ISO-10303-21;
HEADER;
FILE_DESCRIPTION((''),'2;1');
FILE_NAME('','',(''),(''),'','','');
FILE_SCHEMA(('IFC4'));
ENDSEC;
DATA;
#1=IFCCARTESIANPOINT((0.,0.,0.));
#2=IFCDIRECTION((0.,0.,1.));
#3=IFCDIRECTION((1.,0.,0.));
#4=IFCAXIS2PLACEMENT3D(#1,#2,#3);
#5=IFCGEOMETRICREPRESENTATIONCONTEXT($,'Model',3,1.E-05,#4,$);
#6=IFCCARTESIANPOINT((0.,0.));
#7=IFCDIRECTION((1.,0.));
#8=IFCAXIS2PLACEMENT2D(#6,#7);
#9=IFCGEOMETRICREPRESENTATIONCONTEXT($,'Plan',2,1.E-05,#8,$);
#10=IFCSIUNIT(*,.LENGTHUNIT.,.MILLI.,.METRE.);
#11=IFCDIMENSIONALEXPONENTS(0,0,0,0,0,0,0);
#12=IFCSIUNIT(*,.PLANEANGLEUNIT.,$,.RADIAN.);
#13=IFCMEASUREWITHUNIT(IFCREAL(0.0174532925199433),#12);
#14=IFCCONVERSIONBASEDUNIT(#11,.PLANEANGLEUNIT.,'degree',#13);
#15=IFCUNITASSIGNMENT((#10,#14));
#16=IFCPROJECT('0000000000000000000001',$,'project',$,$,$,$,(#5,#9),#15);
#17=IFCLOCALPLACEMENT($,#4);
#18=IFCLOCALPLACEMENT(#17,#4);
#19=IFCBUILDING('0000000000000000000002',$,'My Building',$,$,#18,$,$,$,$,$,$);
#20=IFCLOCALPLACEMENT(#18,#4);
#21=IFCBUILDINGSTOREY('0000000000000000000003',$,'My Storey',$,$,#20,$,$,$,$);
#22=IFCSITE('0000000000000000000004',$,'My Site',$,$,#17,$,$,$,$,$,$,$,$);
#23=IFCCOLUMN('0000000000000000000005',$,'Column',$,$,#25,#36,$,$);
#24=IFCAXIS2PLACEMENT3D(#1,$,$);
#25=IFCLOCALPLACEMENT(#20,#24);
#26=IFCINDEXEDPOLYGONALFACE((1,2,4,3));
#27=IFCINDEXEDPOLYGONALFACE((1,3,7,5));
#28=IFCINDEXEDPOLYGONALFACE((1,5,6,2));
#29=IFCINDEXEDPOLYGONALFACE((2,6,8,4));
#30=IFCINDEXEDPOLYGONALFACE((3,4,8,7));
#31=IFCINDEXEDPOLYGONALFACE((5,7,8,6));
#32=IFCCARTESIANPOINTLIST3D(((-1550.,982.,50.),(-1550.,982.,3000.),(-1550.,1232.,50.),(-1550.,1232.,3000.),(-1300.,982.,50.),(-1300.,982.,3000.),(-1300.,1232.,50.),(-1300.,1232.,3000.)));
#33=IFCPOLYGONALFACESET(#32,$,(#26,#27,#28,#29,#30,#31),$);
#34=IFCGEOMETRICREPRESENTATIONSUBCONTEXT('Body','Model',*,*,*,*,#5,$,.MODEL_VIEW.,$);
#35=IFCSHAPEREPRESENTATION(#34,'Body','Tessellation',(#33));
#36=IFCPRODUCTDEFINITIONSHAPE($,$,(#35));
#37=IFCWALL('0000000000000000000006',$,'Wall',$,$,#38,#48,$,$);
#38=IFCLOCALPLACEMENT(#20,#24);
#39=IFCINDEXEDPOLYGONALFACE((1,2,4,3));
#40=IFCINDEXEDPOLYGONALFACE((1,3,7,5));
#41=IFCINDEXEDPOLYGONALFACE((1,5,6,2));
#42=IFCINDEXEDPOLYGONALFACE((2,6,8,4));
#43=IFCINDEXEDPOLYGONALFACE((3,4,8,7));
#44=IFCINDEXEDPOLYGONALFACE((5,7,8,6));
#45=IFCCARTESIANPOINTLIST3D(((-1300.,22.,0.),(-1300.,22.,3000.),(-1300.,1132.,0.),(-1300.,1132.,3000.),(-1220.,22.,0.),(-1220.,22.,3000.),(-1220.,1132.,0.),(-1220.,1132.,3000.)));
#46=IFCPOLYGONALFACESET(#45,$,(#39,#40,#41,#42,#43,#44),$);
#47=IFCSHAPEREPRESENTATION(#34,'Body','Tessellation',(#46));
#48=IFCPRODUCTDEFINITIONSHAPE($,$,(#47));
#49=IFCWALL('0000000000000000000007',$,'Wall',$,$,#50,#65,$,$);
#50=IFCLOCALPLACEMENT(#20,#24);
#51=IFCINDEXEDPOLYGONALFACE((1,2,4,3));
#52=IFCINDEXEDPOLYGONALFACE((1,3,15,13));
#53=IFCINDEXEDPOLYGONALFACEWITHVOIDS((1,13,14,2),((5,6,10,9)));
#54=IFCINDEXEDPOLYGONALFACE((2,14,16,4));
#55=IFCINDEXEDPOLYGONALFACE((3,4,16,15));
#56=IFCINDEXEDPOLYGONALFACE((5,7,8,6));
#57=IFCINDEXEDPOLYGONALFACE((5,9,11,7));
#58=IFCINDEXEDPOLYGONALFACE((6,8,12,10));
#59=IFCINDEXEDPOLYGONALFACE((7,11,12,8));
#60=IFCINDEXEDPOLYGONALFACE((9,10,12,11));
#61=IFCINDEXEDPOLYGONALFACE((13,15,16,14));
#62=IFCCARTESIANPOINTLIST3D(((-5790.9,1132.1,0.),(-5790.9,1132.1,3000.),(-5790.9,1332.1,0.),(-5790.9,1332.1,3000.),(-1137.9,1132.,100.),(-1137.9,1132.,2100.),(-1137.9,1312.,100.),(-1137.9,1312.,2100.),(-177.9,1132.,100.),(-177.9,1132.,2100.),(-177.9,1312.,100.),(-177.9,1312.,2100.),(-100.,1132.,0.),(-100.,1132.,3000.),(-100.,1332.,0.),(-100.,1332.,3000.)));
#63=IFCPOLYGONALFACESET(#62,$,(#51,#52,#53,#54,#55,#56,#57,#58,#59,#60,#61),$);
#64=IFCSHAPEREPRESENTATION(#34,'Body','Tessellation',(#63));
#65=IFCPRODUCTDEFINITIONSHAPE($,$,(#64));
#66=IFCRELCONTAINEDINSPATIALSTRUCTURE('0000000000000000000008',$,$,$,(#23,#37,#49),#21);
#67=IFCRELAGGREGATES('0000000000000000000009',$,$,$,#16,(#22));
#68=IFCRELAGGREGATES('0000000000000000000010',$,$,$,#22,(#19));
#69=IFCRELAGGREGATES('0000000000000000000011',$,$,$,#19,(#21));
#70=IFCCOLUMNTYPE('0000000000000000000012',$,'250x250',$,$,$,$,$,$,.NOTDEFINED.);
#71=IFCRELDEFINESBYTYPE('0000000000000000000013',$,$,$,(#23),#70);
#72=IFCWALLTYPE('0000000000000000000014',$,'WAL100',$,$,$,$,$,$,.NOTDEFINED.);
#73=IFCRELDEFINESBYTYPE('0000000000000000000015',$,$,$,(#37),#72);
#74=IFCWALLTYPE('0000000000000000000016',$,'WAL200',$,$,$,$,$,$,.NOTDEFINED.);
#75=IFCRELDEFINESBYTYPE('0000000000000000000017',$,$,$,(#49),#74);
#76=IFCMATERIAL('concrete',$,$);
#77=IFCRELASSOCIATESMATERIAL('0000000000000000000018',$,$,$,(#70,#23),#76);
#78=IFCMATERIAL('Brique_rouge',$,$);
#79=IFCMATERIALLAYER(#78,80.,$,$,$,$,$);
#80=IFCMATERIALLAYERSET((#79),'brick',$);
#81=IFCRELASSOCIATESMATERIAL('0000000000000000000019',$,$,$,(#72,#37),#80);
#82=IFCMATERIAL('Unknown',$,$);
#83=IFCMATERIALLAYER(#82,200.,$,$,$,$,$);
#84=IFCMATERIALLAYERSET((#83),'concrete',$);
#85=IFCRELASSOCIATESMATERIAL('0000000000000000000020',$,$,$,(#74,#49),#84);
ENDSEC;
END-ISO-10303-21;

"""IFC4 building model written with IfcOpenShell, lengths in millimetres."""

from ifc_helpers import new_model, entity, si_unit, converted_unit, frame, origin_with_axes, origin_2d_with_axis, place, context, subcontext, project, spatial, line, indexed_curve, rectangle, outline, extrude, source, transform, mapped, material, layer, layer_set, layer_usage, material_profile, profile_set, profile_usage, type_object, element, save


model = new_model("IFC4")

# Units and contexts
model_context = context("Model", 3, precision=1e-05, world=origin_with_axes())
plan_context = context("Plan", 2, precision=1e-05, world=origin_2d_with_axis())
body_context_1 = subcontext(model_context, "Body", "Model", "MODEL_VIEW")
ifc_project = project(units=[si_unit("LENGTHUNIT", "METRE", prefix="MILLI"), converted_unit("PLANEANGLEUNIT", "degree", entity("IfcReal", 0.0174532925199433), si_unit("PLANEANGLEUNIT", "RADIAN"), dimensions=[0, 0, 0, 0, 0, 0, 0])], contexts=[model_context, plan_context])

# Site, building, storey
site_placement = place(None, origin_with_axes())
site = spatial("IfcSite", under=ifc_project, at=site_placement, Name="My Site")
building_placement = place(site_placement, origin_with_axes())
building = spatial("IfcBuilding", under=site, at=building_placement, Name="My Building")
storey_placement = place(building_placement, origin_with_axes())
storey = spatial("IfcBuildingStorey", under=building, at=storey_placement, Name="My Storey")

# Column
ifc_material_1 = material(Name="concrete")
ifc_material_profile = material_profile(ifc_material_1, rectangle(XDim=250.0, YDim=250.0))
ifc_profile_set = profile_set([ifc_material_profile], Name="concrete")
ifc_profile_usage = profile_usage(ifc_profile_set)
column_type = type_object("IfcColumnType", Name="250x250", PredefinedType="NOTDEFINED", material=ifc_profile_set)
column_placement = place(storey_placement, frame((-1425.0, 1107.0, 50.0), z_axis=(0.0, 0.0, 1.0), x_axis=(1.0, 0.0, 0.0)))
element("IfcColumn", 1, at=column_placement, inside=storey, type_object=column_type, material=ifc_profile_usage, Name="Column", context=body_context_1, shape_type="SweptSolid", body=[
    extrude(rectangle(XDim=250.0, YDim=250.0), origin_with_axes(), (0.0, 0.0, 1.0), 2950.0),
])

# Wall
ifc_material_2 = material(Name="Brique_rouge")
ifc_layer_1 = layer(ifc_material_2, 80.0)
ifc_layer_set_1 = layer_set([ifc_layer_1], Name="brick")
ifc_layer_usage_1 = layer_usage(ifc_layer_set_1, "AXIS2", "POSITIVE", 0.0)
wall_type_1 = type_object("IfcWallType", Name="WAL100", PredefinedType="NOTDEFINED", material=ifc_layer_set_1)
wall_1_placement = place(storey_placement, frame((-1300.0, 1132.0, 0.0), z_axis=(0.0, 0.0, 1.0), x_axis=(-0.000001, -1.0, 0.0)))
element("IfcWall", 2, at=wall_1_placement, inside=storey, type_object=wall_type_1, material=ifc_layer_usage_1, Name="Wall", context=body_context_1, shape_type="SweptSolid", body=[
    extrude(outline(indexed_curve([(0.0, 0.0), (0.0, 80.0), (1110.0, 80.0), (1110.0, 0.0), (0.0, 0.0)], self_intersect=False)), origin_with_axes(), (0.0, 0.0, 1.0), 3000.0),
])

# Wall, opening
ifc_material_3 = material(Name="Unknown")
ifc_layer_2 = layer(ifc_material_3, 200.0)
ifc_layer_set_2 = layer_set([ifc_layer_2], Name="concrete")
ifc_layer_usage_2 = layer_usage(ifc_layer_set_2, "AXIS2", "POSITIVE", 0.0)
wall_type_2 = type_object("IfcWallType", Name="WAL200", PredefinedType="NOTDEFINED", material=ifc_layer_set_2)
wall_2_placement = place(storey_placement, frame((-5790.9, 1132.1, 0.0), z_axis=(0.0, 0.0, 1.0), x_axis=(1.0, -0.000001, 0.0)))
wall_2 = element("IfcWall", 3, at=wall_2_placement, inside=storey, type_object=wall_type_2, material=ifc_layer_usage_2, Name="Wall", context=body_context_1, shape_type="SweptSolid", body=[
    extrude(outline(indexed_curve([(0.0, 0.0), (0.0, 200.0), (5690.9, 200.0), (5690.9, 0.0), (0.0, 0.0)], self_intersect=False)), origin_with_axes(), (0.0, 0.0, 1.0), 3000.0),
])
shared_shape_1 = source(origin_with_axes(), body_context_1, "Body", "SweptSolid", [
    extrude(outline(indexed_curve([(0.0, 0.0), (960.0, 0.0), (960.0, 2000.0), (0.0, 2000.0)], segments=[line(1, 2, 3, 4, 1)])), frame((0.0, -100.0, 0.0), z_axis=(0.0, -1.0, 0.0), x_axis=(1.0, 0.0, 0.0)), (0.0, 0.0, -1.0), 280.0),
])
opening_1_placement = place(wall_2_placement, frame((4653.0, 0.0, 100.0), z_axis=(0.0, 0.0, 1.0), x_axis=(1.0, 0.0, 0.0)))
element("IfcOpeningElement", 4, at=opening_1_placement, cuts=wall_2, PredefinedType="OPENING", context=body_context_1, shape_type="MappedRepresentation", body=[
    mapped(shared_shape_1, transform((0.0, 0.0, 0.0), x_axis=(1.0, 0.0, 0.0), y_axis=(0.0, 1.0, 0.0), z_axis=(0.0, 0.0, 1.0), scale=1.0)),
])

save(model, "model.ifc")
